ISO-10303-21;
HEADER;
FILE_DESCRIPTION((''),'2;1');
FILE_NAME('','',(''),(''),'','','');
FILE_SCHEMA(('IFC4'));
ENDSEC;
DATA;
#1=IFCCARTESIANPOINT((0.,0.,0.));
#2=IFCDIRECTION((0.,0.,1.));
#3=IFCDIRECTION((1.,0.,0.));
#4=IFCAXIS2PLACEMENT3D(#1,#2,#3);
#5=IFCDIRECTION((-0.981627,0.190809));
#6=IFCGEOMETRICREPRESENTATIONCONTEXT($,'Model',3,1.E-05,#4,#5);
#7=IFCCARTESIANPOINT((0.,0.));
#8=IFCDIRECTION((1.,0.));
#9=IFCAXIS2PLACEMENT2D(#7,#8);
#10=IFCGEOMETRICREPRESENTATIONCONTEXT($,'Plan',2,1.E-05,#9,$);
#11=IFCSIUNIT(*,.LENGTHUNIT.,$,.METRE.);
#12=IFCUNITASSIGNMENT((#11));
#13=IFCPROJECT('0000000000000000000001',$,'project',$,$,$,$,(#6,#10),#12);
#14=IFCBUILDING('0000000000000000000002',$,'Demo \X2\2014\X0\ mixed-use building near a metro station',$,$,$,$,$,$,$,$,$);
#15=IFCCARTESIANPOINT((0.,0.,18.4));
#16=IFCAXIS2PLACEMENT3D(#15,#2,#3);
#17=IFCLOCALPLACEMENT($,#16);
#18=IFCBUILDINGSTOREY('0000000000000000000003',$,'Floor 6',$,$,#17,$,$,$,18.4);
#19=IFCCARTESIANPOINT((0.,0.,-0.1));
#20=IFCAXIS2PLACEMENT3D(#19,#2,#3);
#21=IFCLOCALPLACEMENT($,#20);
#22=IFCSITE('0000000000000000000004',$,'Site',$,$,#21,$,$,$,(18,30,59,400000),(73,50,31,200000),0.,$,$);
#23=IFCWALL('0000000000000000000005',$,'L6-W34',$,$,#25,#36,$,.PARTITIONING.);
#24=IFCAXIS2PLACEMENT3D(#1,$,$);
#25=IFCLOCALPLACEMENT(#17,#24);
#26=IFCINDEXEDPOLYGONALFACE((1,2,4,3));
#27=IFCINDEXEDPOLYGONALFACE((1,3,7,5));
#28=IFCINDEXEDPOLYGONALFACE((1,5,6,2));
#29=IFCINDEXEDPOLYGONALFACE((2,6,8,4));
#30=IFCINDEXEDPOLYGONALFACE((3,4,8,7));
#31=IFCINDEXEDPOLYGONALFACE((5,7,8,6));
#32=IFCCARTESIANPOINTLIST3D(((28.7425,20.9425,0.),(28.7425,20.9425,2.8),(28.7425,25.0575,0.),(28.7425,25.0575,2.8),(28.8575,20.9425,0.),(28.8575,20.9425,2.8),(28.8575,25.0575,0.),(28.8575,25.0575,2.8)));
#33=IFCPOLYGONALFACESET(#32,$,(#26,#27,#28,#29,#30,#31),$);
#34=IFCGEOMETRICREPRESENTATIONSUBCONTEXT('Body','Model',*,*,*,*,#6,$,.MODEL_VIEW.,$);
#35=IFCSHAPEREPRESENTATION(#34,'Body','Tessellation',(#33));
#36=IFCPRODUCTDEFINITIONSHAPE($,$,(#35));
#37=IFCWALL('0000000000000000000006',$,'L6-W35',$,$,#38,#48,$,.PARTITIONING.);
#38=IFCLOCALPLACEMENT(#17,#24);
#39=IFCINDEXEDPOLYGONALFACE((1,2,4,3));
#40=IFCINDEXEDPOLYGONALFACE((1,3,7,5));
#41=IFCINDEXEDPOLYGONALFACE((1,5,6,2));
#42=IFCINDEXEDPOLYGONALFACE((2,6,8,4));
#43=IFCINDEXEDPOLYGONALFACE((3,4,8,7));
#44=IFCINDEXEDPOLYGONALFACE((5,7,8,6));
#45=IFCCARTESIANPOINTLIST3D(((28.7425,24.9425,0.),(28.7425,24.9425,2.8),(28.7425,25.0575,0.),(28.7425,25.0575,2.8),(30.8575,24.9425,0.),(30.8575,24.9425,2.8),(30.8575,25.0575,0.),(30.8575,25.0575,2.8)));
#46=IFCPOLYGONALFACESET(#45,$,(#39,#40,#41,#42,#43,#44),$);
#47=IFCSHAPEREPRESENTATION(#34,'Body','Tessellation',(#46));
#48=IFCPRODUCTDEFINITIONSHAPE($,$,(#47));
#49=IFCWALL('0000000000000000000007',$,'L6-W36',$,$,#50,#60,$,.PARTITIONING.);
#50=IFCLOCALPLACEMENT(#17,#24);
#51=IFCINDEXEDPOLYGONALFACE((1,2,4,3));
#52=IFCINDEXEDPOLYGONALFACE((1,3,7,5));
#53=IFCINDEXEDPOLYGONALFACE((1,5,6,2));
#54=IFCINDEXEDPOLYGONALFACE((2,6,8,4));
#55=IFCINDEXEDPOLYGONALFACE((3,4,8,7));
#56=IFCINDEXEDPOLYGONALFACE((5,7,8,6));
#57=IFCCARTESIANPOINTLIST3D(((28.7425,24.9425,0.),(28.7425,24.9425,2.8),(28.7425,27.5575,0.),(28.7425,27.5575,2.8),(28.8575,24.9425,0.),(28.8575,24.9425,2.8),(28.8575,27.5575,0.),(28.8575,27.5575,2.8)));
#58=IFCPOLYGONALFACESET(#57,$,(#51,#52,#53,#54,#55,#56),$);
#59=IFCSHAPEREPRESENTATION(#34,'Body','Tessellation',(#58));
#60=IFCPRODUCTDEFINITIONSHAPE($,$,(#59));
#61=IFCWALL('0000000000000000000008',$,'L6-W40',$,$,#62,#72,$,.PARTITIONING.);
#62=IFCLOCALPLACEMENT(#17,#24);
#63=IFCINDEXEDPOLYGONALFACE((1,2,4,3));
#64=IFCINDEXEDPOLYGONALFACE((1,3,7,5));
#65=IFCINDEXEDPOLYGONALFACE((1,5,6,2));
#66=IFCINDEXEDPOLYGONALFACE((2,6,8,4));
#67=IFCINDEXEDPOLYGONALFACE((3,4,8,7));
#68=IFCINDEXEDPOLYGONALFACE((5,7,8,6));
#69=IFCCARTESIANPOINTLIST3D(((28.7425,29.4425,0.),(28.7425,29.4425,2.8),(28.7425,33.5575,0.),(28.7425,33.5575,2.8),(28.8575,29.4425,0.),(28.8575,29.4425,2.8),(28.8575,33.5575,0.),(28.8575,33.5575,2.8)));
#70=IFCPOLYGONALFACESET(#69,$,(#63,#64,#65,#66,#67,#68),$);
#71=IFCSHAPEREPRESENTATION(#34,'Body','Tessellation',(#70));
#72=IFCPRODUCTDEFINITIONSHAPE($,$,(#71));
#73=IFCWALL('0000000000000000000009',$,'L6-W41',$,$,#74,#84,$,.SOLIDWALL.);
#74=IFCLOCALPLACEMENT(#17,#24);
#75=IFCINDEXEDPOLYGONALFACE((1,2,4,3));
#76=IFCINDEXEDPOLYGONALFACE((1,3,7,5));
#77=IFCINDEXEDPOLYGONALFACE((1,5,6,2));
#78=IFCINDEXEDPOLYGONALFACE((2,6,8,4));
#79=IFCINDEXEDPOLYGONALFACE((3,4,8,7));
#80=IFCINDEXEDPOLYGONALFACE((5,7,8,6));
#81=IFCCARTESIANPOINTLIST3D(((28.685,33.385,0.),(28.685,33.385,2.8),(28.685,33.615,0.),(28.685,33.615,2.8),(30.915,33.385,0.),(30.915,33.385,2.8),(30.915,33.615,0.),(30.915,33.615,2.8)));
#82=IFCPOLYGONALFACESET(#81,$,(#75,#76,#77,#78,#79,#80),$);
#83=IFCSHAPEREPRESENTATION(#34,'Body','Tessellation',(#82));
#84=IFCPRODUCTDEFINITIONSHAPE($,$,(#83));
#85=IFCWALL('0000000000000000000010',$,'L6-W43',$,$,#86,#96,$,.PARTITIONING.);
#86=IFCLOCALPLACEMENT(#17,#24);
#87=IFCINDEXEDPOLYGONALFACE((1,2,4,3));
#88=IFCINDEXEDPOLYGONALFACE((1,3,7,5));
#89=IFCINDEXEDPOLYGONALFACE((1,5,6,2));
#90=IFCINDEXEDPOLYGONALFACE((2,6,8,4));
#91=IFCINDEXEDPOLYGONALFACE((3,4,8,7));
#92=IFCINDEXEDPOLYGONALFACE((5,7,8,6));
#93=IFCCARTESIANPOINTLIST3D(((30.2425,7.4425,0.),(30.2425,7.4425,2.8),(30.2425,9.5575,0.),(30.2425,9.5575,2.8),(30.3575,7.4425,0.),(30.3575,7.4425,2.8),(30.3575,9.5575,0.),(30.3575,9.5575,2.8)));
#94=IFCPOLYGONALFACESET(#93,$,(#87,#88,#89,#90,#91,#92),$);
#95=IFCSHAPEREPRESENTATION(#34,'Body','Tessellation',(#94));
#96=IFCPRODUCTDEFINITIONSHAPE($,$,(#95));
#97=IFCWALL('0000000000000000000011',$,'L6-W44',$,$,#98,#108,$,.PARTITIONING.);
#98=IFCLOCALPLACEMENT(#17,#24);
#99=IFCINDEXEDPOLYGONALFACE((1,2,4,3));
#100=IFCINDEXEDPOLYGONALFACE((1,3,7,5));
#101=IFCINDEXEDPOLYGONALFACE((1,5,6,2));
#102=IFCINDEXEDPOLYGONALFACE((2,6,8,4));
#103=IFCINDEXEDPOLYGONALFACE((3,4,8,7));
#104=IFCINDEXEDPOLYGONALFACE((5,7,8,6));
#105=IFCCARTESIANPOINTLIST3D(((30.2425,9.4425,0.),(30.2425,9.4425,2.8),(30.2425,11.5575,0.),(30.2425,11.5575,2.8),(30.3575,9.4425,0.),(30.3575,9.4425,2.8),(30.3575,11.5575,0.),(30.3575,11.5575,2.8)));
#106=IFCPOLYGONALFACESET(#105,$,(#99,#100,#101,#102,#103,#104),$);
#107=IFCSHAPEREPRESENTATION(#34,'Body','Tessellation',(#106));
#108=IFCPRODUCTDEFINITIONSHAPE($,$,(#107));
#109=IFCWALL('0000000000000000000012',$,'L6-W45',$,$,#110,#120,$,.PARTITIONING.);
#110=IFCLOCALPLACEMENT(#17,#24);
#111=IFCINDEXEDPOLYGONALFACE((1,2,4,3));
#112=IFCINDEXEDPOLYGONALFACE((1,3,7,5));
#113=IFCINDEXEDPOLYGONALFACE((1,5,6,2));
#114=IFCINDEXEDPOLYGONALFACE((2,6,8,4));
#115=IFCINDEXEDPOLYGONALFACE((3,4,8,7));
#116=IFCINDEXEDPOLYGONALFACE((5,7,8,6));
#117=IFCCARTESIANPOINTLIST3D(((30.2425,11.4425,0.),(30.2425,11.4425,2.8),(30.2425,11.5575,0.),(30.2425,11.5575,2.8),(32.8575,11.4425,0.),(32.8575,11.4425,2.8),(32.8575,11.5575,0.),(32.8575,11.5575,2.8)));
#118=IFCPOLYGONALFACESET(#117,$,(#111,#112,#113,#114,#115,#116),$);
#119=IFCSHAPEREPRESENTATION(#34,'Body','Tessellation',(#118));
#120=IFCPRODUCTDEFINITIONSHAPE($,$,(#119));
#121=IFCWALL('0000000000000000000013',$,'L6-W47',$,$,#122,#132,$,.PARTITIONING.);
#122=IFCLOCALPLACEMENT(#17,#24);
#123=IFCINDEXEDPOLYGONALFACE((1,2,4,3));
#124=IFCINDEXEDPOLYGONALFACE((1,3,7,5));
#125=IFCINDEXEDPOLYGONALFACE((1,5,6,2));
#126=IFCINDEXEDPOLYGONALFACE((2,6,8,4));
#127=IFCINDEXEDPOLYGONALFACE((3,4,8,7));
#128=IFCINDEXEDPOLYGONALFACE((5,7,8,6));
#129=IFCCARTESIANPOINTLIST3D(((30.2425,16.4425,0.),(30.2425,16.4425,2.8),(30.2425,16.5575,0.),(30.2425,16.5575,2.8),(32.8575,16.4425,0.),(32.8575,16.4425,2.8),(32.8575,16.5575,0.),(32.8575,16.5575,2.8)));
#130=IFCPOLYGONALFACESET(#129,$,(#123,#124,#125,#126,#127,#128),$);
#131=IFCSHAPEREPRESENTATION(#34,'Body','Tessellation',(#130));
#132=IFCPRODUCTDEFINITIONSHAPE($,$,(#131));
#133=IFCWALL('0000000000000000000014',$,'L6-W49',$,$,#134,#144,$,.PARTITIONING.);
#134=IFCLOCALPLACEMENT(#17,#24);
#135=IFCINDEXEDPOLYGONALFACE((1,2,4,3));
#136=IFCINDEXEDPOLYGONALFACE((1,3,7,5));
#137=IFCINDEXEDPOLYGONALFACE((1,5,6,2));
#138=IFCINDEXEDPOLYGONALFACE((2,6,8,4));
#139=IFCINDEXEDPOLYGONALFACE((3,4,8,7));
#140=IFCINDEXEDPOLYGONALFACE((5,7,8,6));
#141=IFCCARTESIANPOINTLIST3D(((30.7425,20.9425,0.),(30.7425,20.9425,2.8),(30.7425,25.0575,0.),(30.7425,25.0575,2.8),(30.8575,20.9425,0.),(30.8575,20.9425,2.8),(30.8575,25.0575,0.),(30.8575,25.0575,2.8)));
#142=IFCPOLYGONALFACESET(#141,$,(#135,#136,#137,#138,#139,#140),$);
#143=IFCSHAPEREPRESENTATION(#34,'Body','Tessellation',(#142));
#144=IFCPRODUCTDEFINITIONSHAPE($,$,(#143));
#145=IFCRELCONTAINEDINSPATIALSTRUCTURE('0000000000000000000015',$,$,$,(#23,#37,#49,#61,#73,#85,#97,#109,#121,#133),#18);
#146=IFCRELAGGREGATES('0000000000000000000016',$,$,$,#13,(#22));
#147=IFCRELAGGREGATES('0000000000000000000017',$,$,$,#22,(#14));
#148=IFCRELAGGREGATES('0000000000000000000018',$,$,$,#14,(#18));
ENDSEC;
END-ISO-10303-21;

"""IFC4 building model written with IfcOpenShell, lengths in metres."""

from ifc_helpers import new_model, si_unit, direction, frame, origin_with_axes, origin_2d_with_axis, place, context, subcontext, project, spatial, line, indexed_curve, outline, extrude, element, save


model = new_model("IFC4")

# Units and contexts
model_context = context("Model", 3, precision=1e-05, world=origin_with_axes(), true_north=direction((-0.981627, 0.190809)))
plan_context = context("Plan", 2, precision=1e-05, world=origin_2d_with_axis())
body_context = subcontext(model_context, "Body", "Model", "MODEL_VIEW")
ifc_project = project(units=[si_unit("LENGTHUNIT", "METRE")], contexts=[model_context, plan_context])

# Site, building, storey
site_placement = place(None, frame((0.0, 0.0, -0.1), z_axis=(0.0, 0.0, 1.0), x_axis=(1.0, 0.0, 0.0)))
site = spatial("IfcSite", under=ifc_project, at=site_placement, Name="Site", RefLatitude=(18, 30, 59, 400000), RefLongitude=(73, 50, 31, 200000), RefElevation=0.0)
building = spatial("IfcBuilding", under=site, Name="Demo — mixed-use building near a metro station")
storey_placement = place(None, frame((0.0, 0.0, 18.4), z_axis=(0.0, 0.0, 1.0), x_axis=(1.0, 0.0, 0.0)))
storey = spatial("IfcBuildingStorey", under=building, at=storey_placement, Name="Floor 6", Elevation=18.4)

# Walls
wall_1_placement = place(storey_placement, frame((0.0, 0.0, -18.4), z_axis=(0.0, 0.0, 1.0), x_axis=(1.0, 0.0, 0.0)))
element("IfcWall", 1, at=wall_1_placement, inside=storey, Name="L6-W34", PredefinedType="PARTITIONING", context=body_context, shape_type="SweptSolid", body=[
    extrude(outline(indexed_curve([(28.7425, 20.9425), (28.7425, 25.0575), (28.8575, 25.0575), (28.8575, 20.9425)], segments=[line(1, 2, 3, 4, 1)])), frame((0.0, 0.0, 18.4), z_axis=(0.0, 0.0, 1.0), x_axis=(1.0, 0.0, 0.0)), (0.0, 0.0, 1.0), 2.8),
])
wall_2_placement = place(storey_placement, frame((0.0, 0.0, -18.4), z_axis=(0.0, 0.0, 1.0), x_axis=(1.0, 0.0, 0.0)))
element("IfcWall", 2, at=wall_2_placement, inside=storey, Name="L6-W35", PredefinedType="PARTITIONING", context=body_context, shape_type="SweptSolid", body=[
    extrude(outline(indexed_curve([(30.8575, 24.9425), (28.7425, 24.9425), (28.7425, 25.0575), (30.8575, 25.0575)], segments=[line(1, 2, 3, 4, 1)])), frame((0.0, 0.0, 18.4), z_axis=(0.0, 0.0, 1.0), x_axis=(1.0, 0.0, 0.0)), (0.0, 0.0, 1.0), 2.8),
])
wall_3_placement = place(storey_placement, frame((0.0, 0.0, -18.4), z_axis=(0.0, 0.0, 1.0), x_axis=(1.0, 0.0, 0.0)))
element("IfcWall", 3, at=wall_3_placement, inside=storey, Name="L6-W36", PredefinedType="PARTITIONING", context=body_context, shape_type="SweptSolid", body=[
    extrude(outline(indexed_curve([(28.7425, 24.9425), (28.7425, 27.5575), (28.8575, 27.5575), (28.8575, 24.9425)], segments=[line(1, 2, 3, 4, 1)])), frame((0.0, 0.0, 18.4), z_axis=(0.0, 0.0, 1.0), x_axis=(1.0, 0.0, 0.0)), (0.0, 0.0, 1.0), 2.8),
])

# Walls
wall_4_placement = place(storey_placement, frame((0.0, 0.0, -18.4), z_axis=(0.0, 0.0, 1.0), x_axis=(1.0, 0.0, 0.0)))
element("IfcWall", 4, at=wall_4_placement, inside=storey, Name="L6-W40", PredefinedType="PARTITIONING", context=body_context, shape_type="SweptSolid", body=[
    extrude(outline(indexed_curve([(28.7425, 29.4425), (28.7425, 33.5575), (28.8575, 33.5575), (28.8575, 29.4425)], segments=[line(1, 2, 3, 4, 1)])), frame((0.0, 0.0, 18.4), z_axis=(0.0, 0.0, 1.0), x_axis=(1.0, 0.0, 0.0)), (0.0, 0.0, 1.0), 2.8),
])
wall_5_placement = place(storey_placement, frame((0.0, 0.0, -18.4), z_axis=(0.0, 0.0, 1.0), x_axis=(1.0, 0.0, 0.0)))
element("IfcWall", 5, at=wall_5_placement, inside=storey, Name="L6-W41", PredefinedType="SOLIDWALL", context=body_context, shape_type="SweptSolid", body=[
    extrude(outline(indexed_curve([(30.915, 33.385), (28.685, 33.385), (28.685, 33.615), (30.915, 33.615)], segments=[line(1, 2, 3, 4, 1)])), frame((0.0, 0.0, 18.4), z_axis=(0.0, 0.0, 1.0), x_axis=(1.0, 0.0, 0.0)), (0.0, 0.0, 1.0), 2.8),
])

# Walls
wall_6_placement = place(storey_placement, frame((0.0, 0.0, -18.4), z_axis=(0.0, 0.0, 1.0), x_axis=(1.0, 0.0, 0.0)))
element("IfcWall", 6, at=wall_6_placement, inside=storey, Name="L6-W43", PredefinedType="PARTITIONING", context=body_context, shape_type="SweptSolid", body=[
    extrude(outline(indexed_curve([(30.2425, 7.4425), (30.2425, 9.5575), (30.3575, 9.5575), (30.3575, 7.4425)], segments=[line(1, 2, 3, 4, 1)])), frame((0.0, 0.0, 18.4), z_axis=(0.0, 0.0, 1.0), x_axis=(1.0, 0.0, 0.0)), (0.0, 0.0, 1.0), 2.8),
])
wall_7_placement = place(storey_placement, frame((0.0, 0.0, -18.4), z_axis=(0.0, 0.0, 1.0), x_axis=(1.0, 0.0, 0.0)))
element("IfcWall", 7, at=wall_7_placement, inside=storey, Name="L6-W44", PredefinedType="PARTITIONING", context=body_context, shape_type="SweptSolid", body=[
    extrude(outline(indexed_curve([(30.2425, 9.4425), (30.2425, 11.5575), (30.3575, 11.5575), (30.3575, 9.4425)], segments=[line(1, 2, 3, 4, 1)])), frame((0.0, 0.0, 18.4), z_axis=(0.0, 0.0, 1.0), x_axis=(1.0, 0.0, 0.0)), (0.0, 0.0, 1.0), 2.8),
])
wall_8_placement = place(storey_placement, frame((0.0, 0.0, -18.4), z_axis=(0.0, 0.0, 1.0), x_axis=(1.0, 0.0, 0.0)))
element("IfcWall", 8, at=wall_8_placement, inside=storey, Name="L6-W45", PredefinedType="PARTITIONING", context=body_context, shape_type="SweptSolid", body=[
    extrude(outline(indexed_curve([(30.2425, 11.5575), (32.8575, 11.5575), (32.8575, 11.4425), (30.2425, 11.4425)], segments=[line(1, 2, 3, 4, 1)])), frame((0.0, 0.0, 18.4), z_axis=(0.0, 0.0, 1.0), x_axis=(1.0, 0.0, 0.0)), (0.0, 0.0, 1.0), 2.8),
])

# Wall
wall_9_placement = place(storey_placement, frame((0.0, 0.0, -18.4), z_axis=(0.0, 0.0, 1.0), x_axis=(1.0, 0.0, 0.0)))
element("IfcWall", 9, at=wall_9_placement, inside=storey, Name="L6-W47", PredefinedType="PARTITIONING", context=body_context, shape_type="SweptSolid", body=[
    extrude(outline(indexed_curve([(32.8575, 16.4425), (30.2425, 16.4425), (30.2425, 16.5575), (32.8575, 16.5575)], segments=[line(1, 2, 3, 4, 1)])), frame((0.0, 0.0, 18.4), z_axis=(0.0, 0.0, 1.0), x_axis=(1.0, 0.0, 0.0)), (0.0, 0.0, 1.0), 2.8),
])

# Wall
wall_10_placement = place(storey_placement, frame((0.0, 0.0, -18.4), z_axis=(0.0, 0.0, 1.0), x_axis=(1.0, 0.0, 0.0)))
element("IfcWall", 10, at=wall_10_placement, inside=storey, Name="L6-W49", PredefinedType="PARTITIONING", context=body_context, shape_type="SweptSolid", body=[
    extrude(outline(indexed_curve([(30.7425, 20.9425), (30.7425, 25.0575), (30.8575, 25.0575), (30.8575, 20.9425)], segments=[line(1, 2, 3, 4, 1)])), frame((0.0, 0.0, 18.4), z_axis=(0.0, 0.0, 1.0), x_axis=(1.0, 0.0, 0.0)), (0.0, 0.0, 1.0), 2.8),
])

save(model, "model.ifc")
